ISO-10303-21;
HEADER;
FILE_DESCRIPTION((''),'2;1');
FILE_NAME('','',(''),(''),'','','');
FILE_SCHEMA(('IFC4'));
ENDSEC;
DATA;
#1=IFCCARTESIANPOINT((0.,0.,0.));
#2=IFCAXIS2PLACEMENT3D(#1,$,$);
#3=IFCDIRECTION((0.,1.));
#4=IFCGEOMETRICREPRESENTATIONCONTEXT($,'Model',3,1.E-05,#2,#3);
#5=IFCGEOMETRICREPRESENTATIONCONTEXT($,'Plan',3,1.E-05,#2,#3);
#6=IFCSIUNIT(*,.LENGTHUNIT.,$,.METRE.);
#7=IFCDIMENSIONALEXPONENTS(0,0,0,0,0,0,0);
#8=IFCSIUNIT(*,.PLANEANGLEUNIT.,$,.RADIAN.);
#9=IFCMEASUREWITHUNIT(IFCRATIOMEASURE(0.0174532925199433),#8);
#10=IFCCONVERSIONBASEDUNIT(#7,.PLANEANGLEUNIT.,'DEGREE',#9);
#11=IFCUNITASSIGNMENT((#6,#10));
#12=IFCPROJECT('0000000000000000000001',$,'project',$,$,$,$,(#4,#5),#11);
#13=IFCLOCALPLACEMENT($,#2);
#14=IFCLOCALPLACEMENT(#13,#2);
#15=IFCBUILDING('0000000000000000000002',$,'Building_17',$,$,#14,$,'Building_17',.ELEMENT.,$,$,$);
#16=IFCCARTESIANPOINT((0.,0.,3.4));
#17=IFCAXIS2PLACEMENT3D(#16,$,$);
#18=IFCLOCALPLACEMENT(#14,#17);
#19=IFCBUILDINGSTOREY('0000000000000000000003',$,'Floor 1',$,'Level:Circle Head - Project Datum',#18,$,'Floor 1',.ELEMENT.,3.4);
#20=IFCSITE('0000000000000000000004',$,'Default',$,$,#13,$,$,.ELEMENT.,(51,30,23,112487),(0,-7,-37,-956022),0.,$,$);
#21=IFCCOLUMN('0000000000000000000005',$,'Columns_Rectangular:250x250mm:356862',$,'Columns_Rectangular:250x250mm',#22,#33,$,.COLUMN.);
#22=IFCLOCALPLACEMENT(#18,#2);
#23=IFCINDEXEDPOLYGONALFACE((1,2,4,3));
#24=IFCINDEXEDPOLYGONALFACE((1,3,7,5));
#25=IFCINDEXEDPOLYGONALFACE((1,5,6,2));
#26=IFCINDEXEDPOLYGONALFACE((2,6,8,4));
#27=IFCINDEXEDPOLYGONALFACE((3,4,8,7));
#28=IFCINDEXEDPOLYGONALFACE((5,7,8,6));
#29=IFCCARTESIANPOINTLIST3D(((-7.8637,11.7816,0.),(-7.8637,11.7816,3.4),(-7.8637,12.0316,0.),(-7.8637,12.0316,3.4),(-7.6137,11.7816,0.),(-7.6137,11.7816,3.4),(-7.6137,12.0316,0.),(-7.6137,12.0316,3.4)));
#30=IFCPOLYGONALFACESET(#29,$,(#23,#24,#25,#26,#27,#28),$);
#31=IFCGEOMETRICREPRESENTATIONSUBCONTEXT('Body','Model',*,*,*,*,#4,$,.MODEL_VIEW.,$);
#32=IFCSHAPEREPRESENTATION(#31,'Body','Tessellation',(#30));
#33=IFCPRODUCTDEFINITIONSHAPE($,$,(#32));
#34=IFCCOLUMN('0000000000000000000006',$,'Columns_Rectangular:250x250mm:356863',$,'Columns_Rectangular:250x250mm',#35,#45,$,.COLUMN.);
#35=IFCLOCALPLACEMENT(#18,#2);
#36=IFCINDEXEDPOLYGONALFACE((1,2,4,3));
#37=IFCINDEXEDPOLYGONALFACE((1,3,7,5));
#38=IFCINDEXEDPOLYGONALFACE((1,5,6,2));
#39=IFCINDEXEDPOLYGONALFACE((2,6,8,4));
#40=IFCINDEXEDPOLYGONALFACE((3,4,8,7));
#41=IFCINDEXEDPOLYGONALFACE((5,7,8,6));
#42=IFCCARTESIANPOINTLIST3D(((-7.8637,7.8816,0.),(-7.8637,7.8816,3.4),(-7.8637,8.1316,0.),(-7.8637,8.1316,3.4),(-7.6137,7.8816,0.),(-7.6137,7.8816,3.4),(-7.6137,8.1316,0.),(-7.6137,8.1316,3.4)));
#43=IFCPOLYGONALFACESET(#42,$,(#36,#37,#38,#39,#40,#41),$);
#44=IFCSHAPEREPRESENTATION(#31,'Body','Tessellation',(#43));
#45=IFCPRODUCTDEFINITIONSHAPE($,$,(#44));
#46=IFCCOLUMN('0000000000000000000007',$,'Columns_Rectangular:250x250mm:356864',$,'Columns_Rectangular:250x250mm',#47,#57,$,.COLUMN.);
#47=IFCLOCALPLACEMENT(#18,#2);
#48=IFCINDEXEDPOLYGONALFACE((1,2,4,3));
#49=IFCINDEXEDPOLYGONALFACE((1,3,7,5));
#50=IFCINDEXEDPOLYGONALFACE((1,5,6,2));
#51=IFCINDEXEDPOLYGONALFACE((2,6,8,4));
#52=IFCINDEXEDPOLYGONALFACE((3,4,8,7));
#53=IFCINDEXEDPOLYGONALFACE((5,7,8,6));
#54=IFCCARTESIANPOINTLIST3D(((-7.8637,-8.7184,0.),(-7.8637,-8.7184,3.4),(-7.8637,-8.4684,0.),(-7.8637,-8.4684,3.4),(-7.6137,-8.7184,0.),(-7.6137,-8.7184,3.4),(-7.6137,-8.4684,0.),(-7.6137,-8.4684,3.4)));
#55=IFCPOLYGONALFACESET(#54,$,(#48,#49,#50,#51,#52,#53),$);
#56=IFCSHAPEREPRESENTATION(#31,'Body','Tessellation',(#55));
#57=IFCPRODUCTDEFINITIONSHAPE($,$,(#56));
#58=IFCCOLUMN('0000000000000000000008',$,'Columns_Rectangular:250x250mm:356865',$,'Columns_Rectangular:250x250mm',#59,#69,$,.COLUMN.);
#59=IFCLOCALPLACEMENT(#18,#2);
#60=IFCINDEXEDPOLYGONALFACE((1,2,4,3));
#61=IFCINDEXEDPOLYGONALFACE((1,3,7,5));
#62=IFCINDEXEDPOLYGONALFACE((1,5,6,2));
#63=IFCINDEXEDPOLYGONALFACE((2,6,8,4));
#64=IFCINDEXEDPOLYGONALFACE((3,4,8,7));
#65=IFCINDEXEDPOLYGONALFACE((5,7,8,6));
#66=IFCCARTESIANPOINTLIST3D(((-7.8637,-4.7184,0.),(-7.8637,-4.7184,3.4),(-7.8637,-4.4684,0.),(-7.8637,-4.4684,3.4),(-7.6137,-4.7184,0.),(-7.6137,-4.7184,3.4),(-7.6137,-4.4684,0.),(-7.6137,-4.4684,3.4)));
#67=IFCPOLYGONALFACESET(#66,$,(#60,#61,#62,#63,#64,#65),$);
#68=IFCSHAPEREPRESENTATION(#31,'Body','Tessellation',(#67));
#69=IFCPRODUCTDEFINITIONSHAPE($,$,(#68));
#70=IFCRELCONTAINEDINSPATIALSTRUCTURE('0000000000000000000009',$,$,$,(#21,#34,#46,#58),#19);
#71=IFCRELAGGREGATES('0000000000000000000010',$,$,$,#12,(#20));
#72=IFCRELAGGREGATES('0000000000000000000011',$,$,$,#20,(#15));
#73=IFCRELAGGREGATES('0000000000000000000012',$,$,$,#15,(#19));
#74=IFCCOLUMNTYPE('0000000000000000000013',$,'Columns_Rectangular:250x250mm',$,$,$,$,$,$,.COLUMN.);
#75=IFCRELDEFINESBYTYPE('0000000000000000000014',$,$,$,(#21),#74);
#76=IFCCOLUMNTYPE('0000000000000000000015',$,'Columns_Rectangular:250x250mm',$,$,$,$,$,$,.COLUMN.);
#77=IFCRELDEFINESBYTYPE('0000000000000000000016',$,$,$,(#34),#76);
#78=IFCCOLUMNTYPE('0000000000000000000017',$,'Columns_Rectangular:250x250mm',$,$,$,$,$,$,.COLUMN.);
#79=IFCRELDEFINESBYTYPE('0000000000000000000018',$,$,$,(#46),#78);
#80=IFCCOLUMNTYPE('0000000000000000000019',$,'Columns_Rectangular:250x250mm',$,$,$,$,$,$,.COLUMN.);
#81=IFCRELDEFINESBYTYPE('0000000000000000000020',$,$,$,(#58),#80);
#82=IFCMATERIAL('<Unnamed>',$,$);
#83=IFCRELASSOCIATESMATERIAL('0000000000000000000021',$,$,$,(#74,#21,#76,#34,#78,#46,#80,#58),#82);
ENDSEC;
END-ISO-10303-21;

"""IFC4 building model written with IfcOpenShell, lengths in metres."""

from ifc_helpers import new_model, entity, si_unit, converted_unit, direction, frame, origin, place, context, subcontext, project, spatial, indexed_curve, outline, extrude, source, transform, mapped, material, type_object, type_shapes, element, save


model = new_model("IFC4")

# Units and contexts
model_context = context("Model", 3, precision=1e-05, world=origin(), true_north=direction((0.0, 1.0)))
plan_context = context("Plan", 3, precision=1e-05, world=origin(), true_north=direction((0.0, 1.0)))
body_context = subcontext(model_context, "Body", "Model", "MODEL_VIEW")
ifc_project = project(units=[si_unit("LENGTHUNIT", "METRE"), converted_unit("PLANEANGLEUNIT", "DEGREE", entity("IfcRatioMeasure", 0.0174532925199433), si_unit("PLANEANGLEUNIT", "RADIAN"), dimensions=[0, 0, 0, 0, 0, 0, 0])], contexts=[model_context, plan_context])

# Site, building, storey
site_placement = place(None, origin())
site = spatial("IfcSite", under=ifc_project, at=site_placement, Name="Default", CompositionType="ELEMENT", RefLatitude=(51, 30, 23, 112487), RefLongitude=(0, -7, -37, -956022), RefElevation=0.0)
building_placement = place(site_placement, origin())
building = spatial("IfcBuilding", under=site, at=building_placement, Name="Building_17", LongName="Building_17", CompositionType="ELEMENT")
storey_placement = place(building_placement, frame((0.0, 0.0, 3.4)))
storey = spatial("IfcBuildingStorey", under=building, at=storey_placement, Name="Floor 1", ObjectType="Level:Circle Head - Project Datum", LongName="Floor 1", CompositionType="ELEMENT", Elevation=3.4)

# Columns
ifc_material_1 = material(Name="<Unnamed>")
column_type_1 = type_object("IfcColumnType", Name="Columns_Rectangular:250x250mm", PredefinedType="COLUMN", material=ifc_material_1)
shared_shape_1 = source(origin(), body_context, "Body", "SweptSolid", [
    extrude(outline(indexed_curve([(-0.125, -0.125), (0.125, -0.125), (0.125, 0.125), (-0.125, 0.125), (-0.125, -0.125)], self_intersect=False)), frame((-7.7387, 11.9066, 3.4), z_axis=(0.0, 0.0, 1.0), x_axis=(0.0, -1.0, 0.0)), (0.0, 0.0, 1.0), 3.4),
])
type_shapes(column_type_1, [shared_shape_1])
column_1_placement = place(storey_placement, frame((0.0, 0.0, -3.4)))
element("IfcColumn", 1, at=column_1_placement, inside=storey, type_object=column_type_1, material=ifc_material_1, Name="Columns_Rectangular:250x250mm:356862", ObjectType="Columns_Rectangular:250x250mm", PredefinedType="COLUMN", context=body_context, shape_type="MappedRepresentation", body=[
    mapped(shared_shape_1, transform((0.0, 0.0, 0.0), scale=1.0)),
])
column_type_2 = type_object("IfcColumnType", Name="Columns_Rectangular:250x250mm", PredefinedType="COLUMN", material=ifc_material_1)
shared_shape_2 = source(origin(), body_context, "Body", "SweptSolid", [
    extrude(outline(indexed_curve([(-0.125, -0.125), (0.125, -0.125), (0.125, 0.125), (-0.125, 0.125), (-0.125, -0.125)], self_intersect=False)), frame((-7.7387, 8.0066, 3.4), z_axis=(0.0, 0.0, 1.0), x_axis=(0.0, -1.0, 0.0)), (0.0, 0.0, 1.0), 3.4),
])
type_shapes(column_type_2, [shared_shape_2])
column_2_placement = place(storey_placement, frame((0.0, 0.0, -3.4)))
element("IfcColumn", 2, at=column_2_placement, inside=storey, type_object=column_type_2, material=ifc_material_1, Name="Columns_Rectangular:250x250mm:356863", ObjectType="Columns_Rectangular:250x250mm", PredefinedType="COLUMN", context=body_context, shape_type="MappedRepresentation", body=[
    mapped(shared_shape_2, transform((0.0, 0.0, 0.0), scale=1.0)),
])
column_type_3 = type_object("IfcColumnType", Name="Columns_Rectangular:250x250mm", PredefinedType="COLUMN", material=ifc_material_1)
shared_shape_3 = source(origin(), body_context, "Body", "SweptSolid", [
    extrude(outline(indexed_curve([(-0.125, -0.125), (0.125, -0.125), (0.125, 0.125), (-0.125, 0.125), (-0.125, -0.125)], self_intersect=False)), frame((-7.7387, -8.5934, 3.4), z_axis=(0.0, 0.0, 1.0), x_axis=(0.0, -1.0, 0.0)), (0.0, 0.0, 1.0), 3.4),
])
type_shapes(column_type_3, [shared_shape_3])
column_3_placement = place(storey_placement, frame((0.0, 0.0, -3.4)))
element("IfcColumn", 3, at=column_3_placement, inside=storey, type_object=column_type_3, material=ifc_material_1, Name="Columns_Rectangular:250x250mm:356864", ObjectType="Columns_Rectangular:250x250mm", PredefinedType="COLUMN", context=body_context, shape_type="MappedRepresentation", body=[
    mapped(shared_shape_3, transform((0.0, 0.0, 0.0), scale=1.0)),
])
column_type_4 = type_object("IfcColumnType", Name="Columns_Rectangular:250x250mm", PredefinedType="COLUMN", material=ifc_material_1)
shared_shape_4 = source(origin(), body_context, "Body", "SweptSolid", [
    extrude(outline(indexed_curve([(-0.125, -0.125), (0.125, -0.125), (0.125, 0.125), (-0.125, 0.125), (-0.125, -0.125)], self_intersect=False)), frame((-7.7387, -4.5934, 3.4), z_axis=(0.0, 0.0, 1.0), x_axis=(0.0, -1.0, 0.0)), (0.0, 0.0, 1.0), 3.4),
])
type_shapes(column_type_4, [shared_shape_4])
column_4_placement = place(storey_placement, frame((0.0, 0.0, -3.4)))
element("IfcColumn", 4, at=column_4_placement, inside=storey, type_object=column_type_4, material=ifc_material_1, Name="Columns_Rectangular:250x250mm:356865", ObjectType="Columns_Rectangular:250x250mm", PredefinedType="COLUMN", context=body_context, shape_type="MappedRepresentation", body=[
    mapped(shared_shape_4, transform((0.0, 0.0, 0.0), scale=1.0)),
])

save(model, "model.ifc")
